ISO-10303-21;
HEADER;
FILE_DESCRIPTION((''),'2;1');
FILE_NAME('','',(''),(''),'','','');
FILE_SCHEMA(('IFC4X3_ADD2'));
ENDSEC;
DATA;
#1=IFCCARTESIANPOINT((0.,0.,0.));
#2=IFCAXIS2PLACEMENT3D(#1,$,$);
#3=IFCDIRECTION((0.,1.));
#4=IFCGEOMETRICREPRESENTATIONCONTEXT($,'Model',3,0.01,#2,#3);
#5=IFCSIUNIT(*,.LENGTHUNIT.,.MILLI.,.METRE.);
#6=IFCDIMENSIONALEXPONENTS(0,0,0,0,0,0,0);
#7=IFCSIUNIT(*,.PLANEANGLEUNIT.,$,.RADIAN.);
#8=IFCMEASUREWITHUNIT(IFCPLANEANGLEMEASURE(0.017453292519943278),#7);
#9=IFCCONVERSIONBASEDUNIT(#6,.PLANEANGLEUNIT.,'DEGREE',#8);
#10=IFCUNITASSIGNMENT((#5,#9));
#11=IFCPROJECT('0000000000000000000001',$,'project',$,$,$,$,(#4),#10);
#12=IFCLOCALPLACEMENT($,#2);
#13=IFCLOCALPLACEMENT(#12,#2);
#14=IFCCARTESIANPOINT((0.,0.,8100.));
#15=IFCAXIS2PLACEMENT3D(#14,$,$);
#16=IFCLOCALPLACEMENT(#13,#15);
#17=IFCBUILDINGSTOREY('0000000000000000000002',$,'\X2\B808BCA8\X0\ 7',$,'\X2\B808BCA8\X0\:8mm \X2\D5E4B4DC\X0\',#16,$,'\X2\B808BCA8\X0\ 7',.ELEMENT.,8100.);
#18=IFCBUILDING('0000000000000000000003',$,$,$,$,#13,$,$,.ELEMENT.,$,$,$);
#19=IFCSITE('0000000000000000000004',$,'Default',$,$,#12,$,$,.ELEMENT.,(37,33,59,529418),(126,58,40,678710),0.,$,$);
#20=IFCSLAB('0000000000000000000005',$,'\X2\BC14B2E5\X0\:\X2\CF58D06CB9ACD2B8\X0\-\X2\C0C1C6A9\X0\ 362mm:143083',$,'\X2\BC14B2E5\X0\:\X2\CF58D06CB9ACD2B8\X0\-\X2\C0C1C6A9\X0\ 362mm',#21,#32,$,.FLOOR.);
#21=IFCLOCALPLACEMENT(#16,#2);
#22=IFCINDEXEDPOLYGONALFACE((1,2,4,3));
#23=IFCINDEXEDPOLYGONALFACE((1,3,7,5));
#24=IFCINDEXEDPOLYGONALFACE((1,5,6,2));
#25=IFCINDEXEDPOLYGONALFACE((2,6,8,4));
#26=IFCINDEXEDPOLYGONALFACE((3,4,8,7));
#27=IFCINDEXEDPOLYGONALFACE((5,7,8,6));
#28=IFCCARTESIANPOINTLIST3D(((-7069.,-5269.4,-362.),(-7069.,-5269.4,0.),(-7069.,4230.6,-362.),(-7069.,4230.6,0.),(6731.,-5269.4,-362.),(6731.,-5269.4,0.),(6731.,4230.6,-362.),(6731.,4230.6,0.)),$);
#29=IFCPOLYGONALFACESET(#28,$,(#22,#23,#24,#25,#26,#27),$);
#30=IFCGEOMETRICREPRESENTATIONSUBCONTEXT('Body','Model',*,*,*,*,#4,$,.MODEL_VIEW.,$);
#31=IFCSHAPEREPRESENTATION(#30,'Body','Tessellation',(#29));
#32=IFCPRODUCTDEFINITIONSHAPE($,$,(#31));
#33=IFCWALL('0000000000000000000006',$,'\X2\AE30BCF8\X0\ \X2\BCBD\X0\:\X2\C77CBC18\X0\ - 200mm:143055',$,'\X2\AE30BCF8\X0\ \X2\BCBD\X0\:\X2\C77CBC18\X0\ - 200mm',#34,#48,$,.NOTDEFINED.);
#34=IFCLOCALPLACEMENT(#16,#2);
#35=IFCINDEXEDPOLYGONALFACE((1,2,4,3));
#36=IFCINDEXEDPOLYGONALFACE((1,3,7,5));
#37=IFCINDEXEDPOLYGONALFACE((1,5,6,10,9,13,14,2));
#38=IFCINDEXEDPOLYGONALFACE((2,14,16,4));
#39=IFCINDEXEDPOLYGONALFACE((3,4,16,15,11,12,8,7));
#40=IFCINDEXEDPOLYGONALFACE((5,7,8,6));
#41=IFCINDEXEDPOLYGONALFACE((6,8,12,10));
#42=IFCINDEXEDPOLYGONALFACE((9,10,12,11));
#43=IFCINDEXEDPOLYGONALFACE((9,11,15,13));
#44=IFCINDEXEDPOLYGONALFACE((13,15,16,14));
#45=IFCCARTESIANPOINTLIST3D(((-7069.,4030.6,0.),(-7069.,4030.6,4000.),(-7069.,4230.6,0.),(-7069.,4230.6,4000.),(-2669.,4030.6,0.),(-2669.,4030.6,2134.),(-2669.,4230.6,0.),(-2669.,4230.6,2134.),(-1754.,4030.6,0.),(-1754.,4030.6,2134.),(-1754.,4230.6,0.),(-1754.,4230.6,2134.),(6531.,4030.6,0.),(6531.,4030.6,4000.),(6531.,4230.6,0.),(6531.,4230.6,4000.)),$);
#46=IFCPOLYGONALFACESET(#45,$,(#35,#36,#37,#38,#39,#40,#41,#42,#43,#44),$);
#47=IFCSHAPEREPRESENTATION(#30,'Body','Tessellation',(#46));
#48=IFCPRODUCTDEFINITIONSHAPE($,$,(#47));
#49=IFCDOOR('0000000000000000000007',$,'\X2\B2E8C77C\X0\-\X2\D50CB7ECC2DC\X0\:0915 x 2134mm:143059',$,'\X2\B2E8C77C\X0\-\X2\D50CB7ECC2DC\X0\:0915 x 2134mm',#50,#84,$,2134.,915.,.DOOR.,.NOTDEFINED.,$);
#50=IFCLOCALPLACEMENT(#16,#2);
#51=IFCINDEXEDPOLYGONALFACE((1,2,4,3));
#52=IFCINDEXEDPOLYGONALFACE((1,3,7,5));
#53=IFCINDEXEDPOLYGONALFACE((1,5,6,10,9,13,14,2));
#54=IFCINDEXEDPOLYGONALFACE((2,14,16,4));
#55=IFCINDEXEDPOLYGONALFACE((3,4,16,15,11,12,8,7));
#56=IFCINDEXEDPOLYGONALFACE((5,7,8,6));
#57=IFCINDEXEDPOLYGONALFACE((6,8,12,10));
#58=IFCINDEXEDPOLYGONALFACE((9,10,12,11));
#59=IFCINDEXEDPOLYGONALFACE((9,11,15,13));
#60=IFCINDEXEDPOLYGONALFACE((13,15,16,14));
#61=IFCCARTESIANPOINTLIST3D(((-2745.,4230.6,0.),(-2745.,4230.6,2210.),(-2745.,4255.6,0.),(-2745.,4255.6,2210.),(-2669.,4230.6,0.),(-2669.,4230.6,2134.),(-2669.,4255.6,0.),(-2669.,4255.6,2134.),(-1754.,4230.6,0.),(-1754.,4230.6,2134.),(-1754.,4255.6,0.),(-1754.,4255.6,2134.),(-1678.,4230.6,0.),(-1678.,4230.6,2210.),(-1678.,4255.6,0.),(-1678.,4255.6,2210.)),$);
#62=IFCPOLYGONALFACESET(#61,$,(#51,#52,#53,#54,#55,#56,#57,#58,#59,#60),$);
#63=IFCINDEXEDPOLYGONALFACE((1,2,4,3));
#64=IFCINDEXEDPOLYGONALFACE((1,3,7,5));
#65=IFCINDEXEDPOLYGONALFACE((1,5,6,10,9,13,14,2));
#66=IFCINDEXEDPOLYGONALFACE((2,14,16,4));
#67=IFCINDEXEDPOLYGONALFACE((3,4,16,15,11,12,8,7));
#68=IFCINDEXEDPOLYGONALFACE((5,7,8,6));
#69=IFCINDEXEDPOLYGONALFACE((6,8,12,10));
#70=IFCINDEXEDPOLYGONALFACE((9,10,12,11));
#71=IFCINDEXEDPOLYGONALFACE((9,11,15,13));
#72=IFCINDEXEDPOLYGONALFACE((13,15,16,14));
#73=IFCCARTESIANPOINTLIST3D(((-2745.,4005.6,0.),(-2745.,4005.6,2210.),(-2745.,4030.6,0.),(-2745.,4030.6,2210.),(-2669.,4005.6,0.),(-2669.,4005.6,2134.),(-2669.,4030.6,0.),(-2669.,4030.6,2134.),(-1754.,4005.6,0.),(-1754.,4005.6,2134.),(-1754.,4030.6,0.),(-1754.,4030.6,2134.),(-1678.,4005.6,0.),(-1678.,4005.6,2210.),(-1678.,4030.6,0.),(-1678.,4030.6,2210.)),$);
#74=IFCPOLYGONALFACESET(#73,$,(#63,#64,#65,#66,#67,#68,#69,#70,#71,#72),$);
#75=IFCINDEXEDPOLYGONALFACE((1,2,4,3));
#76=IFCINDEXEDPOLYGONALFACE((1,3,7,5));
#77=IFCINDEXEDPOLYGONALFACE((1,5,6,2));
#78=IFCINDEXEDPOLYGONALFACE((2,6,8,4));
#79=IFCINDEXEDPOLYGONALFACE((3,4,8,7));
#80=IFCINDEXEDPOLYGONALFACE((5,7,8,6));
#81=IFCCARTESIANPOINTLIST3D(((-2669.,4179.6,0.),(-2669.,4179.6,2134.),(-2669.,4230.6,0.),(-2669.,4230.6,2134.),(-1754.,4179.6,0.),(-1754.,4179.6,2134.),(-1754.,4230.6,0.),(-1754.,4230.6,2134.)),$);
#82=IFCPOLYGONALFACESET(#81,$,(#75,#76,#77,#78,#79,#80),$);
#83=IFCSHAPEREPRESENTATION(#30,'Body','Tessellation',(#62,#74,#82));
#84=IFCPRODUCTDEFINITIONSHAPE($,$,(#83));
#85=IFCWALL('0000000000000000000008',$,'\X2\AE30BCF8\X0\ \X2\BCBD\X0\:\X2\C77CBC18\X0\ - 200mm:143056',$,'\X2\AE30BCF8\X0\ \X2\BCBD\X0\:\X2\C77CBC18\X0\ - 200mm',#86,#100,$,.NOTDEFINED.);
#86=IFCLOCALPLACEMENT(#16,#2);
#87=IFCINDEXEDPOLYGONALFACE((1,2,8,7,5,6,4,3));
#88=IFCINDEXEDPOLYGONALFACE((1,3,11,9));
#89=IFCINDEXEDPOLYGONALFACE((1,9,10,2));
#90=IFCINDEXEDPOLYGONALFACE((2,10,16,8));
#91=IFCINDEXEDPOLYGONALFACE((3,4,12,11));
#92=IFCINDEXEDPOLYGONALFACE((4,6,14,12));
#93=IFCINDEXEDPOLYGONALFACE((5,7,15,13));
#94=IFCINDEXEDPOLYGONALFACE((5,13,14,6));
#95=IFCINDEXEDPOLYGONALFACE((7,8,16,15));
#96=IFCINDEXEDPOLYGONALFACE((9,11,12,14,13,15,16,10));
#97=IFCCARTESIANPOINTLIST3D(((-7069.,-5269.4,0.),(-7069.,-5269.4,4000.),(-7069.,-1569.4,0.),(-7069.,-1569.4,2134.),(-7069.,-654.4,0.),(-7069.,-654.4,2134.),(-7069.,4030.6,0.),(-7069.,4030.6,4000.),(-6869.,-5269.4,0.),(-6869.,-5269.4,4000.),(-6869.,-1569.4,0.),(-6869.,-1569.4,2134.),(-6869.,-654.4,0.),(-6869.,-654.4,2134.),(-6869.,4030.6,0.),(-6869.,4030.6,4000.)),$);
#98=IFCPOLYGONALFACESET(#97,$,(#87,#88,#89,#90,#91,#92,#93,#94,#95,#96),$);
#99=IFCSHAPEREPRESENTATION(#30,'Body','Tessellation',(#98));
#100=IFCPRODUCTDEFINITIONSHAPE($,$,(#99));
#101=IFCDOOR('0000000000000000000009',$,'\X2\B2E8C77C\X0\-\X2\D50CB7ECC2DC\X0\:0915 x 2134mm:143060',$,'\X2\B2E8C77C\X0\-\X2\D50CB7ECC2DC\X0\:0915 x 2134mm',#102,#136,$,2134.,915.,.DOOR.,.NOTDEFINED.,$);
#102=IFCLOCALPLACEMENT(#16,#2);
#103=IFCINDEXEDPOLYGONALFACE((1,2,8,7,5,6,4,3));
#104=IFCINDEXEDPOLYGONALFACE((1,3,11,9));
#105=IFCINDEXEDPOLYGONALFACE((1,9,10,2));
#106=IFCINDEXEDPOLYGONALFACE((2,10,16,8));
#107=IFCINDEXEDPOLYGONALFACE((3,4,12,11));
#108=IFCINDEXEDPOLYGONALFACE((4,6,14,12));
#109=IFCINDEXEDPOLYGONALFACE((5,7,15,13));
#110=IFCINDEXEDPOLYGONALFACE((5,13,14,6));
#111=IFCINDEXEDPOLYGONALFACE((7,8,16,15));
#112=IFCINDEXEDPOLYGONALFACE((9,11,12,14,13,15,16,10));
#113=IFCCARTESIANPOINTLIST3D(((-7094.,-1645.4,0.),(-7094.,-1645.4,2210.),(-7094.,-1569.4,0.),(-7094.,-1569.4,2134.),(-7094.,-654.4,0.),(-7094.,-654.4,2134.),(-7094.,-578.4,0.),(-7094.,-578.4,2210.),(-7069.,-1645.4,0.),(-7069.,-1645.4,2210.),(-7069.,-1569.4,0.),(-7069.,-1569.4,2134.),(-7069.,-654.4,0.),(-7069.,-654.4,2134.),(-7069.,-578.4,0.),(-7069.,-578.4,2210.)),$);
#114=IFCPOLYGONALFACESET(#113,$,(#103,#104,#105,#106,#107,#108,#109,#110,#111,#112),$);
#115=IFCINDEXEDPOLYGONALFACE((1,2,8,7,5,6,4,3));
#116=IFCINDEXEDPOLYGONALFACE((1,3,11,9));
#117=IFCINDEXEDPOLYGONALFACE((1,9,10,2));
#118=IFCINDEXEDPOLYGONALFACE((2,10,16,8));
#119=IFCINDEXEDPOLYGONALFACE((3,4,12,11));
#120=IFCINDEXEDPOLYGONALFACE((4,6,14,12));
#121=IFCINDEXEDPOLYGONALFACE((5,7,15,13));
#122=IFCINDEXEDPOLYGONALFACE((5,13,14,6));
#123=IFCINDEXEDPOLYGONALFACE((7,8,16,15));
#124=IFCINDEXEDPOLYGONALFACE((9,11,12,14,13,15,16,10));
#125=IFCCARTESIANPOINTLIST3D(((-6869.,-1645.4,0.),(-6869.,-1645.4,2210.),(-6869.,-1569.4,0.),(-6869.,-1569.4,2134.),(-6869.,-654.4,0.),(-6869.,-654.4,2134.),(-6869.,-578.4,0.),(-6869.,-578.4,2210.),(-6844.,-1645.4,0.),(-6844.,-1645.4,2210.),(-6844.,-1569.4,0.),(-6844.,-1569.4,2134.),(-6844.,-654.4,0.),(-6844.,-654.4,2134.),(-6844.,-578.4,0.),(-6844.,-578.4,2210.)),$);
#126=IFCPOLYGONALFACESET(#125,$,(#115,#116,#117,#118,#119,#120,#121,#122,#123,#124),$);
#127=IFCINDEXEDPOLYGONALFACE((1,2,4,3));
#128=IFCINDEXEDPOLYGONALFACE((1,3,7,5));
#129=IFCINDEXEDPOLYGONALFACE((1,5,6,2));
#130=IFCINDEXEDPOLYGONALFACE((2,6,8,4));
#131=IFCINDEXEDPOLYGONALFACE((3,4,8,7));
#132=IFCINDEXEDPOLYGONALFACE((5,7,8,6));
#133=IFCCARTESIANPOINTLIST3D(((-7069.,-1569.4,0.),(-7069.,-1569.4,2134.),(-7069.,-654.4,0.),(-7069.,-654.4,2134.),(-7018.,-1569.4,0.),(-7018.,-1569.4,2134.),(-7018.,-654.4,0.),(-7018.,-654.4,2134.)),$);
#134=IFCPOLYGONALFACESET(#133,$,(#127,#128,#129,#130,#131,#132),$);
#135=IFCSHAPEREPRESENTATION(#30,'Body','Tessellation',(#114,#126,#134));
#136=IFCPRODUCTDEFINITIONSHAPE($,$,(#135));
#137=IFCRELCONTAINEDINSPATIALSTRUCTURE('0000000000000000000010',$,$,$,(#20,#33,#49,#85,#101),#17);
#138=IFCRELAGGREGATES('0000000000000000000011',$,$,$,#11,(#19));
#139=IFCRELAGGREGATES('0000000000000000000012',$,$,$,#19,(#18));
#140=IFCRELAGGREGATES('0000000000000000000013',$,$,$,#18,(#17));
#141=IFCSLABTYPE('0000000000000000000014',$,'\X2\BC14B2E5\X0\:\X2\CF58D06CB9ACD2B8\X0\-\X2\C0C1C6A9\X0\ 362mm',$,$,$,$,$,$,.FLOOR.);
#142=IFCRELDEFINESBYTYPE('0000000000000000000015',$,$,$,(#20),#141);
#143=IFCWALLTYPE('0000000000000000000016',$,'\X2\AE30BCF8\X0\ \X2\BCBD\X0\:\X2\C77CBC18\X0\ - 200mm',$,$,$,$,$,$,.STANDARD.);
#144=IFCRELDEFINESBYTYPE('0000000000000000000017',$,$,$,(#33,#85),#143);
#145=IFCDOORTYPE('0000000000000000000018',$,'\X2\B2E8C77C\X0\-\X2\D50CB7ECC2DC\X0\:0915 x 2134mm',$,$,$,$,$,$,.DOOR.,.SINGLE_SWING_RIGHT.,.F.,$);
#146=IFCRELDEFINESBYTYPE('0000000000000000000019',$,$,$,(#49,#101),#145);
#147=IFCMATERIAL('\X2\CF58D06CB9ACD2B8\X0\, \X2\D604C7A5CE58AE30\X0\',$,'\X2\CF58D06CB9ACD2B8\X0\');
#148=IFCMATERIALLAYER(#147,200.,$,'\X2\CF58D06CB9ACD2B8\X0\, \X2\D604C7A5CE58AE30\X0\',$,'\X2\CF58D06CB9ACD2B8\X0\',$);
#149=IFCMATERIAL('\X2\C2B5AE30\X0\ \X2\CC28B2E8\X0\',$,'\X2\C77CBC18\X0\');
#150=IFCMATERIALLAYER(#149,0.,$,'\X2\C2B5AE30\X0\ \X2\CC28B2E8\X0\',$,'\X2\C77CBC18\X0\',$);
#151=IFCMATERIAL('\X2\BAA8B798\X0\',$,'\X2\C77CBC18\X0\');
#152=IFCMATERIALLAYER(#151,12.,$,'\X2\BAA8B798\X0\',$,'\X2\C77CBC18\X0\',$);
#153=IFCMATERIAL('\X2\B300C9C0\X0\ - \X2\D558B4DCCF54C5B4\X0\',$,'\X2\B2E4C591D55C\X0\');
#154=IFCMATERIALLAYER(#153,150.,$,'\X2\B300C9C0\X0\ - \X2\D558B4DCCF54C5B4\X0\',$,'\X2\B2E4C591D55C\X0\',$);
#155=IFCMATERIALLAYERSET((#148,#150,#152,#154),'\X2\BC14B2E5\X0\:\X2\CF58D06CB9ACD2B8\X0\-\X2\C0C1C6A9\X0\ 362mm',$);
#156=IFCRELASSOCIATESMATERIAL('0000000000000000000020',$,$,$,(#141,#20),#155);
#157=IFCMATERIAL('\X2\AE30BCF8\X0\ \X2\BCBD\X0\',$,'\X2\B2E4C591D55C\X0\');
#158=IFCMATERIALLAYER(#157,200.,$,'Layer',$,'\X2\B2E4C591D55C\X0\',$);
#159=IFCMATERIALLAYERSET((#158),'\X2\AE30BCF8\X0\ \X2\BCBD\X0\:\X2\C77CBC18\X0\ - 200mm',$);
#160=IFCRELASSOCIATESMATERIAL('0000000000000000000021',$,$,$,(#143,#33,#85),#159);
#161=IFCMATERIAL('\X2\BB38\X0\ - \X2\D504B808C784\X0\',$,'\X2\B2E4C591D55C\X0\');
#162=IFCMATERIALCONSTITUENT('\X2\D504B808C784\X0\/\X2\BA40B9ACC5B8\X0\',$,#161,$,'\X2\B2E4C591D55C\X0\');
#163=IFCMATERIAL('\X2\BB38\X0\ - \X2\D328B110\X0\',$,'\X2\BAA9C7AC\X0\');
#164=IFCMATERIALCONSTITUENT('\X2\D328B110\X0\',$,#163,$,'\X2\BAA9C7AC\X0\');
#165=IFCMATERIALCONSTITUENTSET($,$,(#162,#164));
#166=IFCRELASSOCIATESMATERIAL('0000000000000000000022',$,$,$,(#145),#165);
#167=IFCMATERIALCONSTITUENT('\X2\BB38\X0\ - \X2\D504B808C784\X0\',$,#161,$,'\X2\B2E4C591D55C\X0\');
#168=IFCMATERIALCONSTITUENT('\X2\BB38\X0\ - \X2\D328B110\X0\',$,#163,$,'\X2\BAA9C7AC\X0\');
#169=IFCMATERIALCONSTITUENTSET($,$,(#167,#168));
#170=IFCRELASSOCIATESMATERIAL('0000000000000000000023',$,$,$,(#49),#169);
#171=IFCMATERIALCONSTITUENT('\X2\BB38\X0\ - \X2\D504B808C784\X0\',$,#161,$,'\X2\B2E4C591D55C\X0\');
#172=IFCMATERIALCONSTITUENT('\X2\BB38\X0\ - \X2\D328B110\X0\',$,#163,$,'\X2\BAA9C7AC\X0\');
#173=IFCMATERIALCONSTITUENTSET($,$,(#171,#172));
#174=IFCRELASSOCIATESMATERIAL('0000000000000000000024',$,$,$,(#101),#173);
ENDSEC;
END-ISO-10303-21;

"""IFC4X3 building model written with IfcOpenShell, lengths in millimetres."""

from ifc_helpers import new_model, entity, si_unit, converted_unit, direction, frame, frame_2d, origin, origin_2d_with_axis, place, context, subcontext, project, spatial, polyline, rectangle, outline, extrude, source, transform, mapped, material, layer, layer_set, layer_usage, constituent, constituent_set, type_object, type_shapes, element, fill, save


model = new_model("IFC4X3")

# Units and contexts
model_context = context("Model", 3, precision=0.01, world=origin(), true_north=direction((0.0, 1.0)))
body_context = subcontext(model_context, "Body", "Model", "MODEL_VIEW")
ifc_project = project(units=[si_unit("LENGTHUNIT", "METRE", prefix="MILLI"), converted_unit("PLANEANGLEUNIT", "DEGREE", entity("IfcPlaneAngleMeasure", 0.017453292519943278), si_unit("PLANEANGLEUNIT", "RADIAN"), dimensions=[0, 0, 0, 0, 0, 0, 0])], contexts=[model_context])

# Site, building, storey
site_placement = place(None, origin())
site = spatial("IfcSite", under=ifc_project, at=site_placement, Name="Default", CompositionType="ELEMENT", RefLatitude=(37, 33, 59, 529418), RefLongitude=(126, 58, 40, 678710), RefElevation=0.0)
building_placement = place(site_placement, origin())
building = spatial("IfcBuilding", under=site, at=building_placement, CompositionType="ELEMENT")
storey_placement = place(building_placement, frame((0.0, 0.0, 8100.0)))
storey = spatial("IfcBuildingStorey", under=building, at=storey_placement, Name="레벨 7", ObjectType="레벨:8mm 헤드", LongName="레벨 7", CompositionType="ELEMENT", Elevation=8100.0)

# Slab
ifc_material_1 = material(Name="콘크리트, 현장치기", Category="콘크리트")
ifc_layer_1 = layer(ifc_material_1, 200.0, Name="콘크리트, 현장치기", Category="콘크리트")
ifc_material_2 = material(Name="습기 차단", Category="일반")
ifc_layer_2 = layer(ifc_material_2, 0.0, Name="습기 차단", Category="일반")
ifc_material_3 = material(Name="모래", Category="일반")
ifc_layer_3 = layer(ifc_material_3, 12.0, Name="모래", Category="일반")
ifc_material_4 = material(Name="대지 - 하드코어", Category="다양한")
ifc_layer_4 = layer(ifc_material_4, 150.0, Name="대지 - 하드코어", Category="다양한")
ifc_layer_set_1 = layer_set([ifc_layer_1, ifc_layer_2, ifc_layer_3, ifc_layer_4], Name="바닥:콘크리트-상용 362mm")
ifc_layer_usage_1 = layer_usage(ifc_layer_set_1, "AXIS3", "POSITIVE", 0.0)
slab_type = type_object("IfcSlabType", Name="바닥:콘크리트-상용 362mm", PredefinedType="FLOOR", material=ifc_layer_set_1)
slab_placement = place(storey_placement, origin())
element("IfcSlab", 1, at=slab_placement, inside=storey, type_object=slab_type, material=ifc_layer_usage_1, Name="바닥:콘크리트-상용 362mm:143083", ObjectType="바닥:콘크리트-상용 362mm", PredefinedType="FLOOR", context=body_context, shape_type="SweptSolid", body=[
    extrude(rectangle(XDim=9500.0, YDim=13800.0, at=origin_2d_with_axis()), frame((-169.0, -519.4, 0.0), z_axis=(0.0, 0.0, -1.0), x_axis=(0.0, 1.0, 0.0)), (0.0, 0.0, 1.0), 362.0),
])

# Walls, openings, doors
ifc_material_5 = material(Name="기본 벽", Category="다양한")
ifc_layer_5 = layer(ifc_material_5, 200.0, Name="Layer", Category="다양한")
ifc_layer_set_2 = layer_set([ifc_layer_5], Name="기본 벽:일반 - 200mm")
wall_type = type_object("IfcWallType", Name="기본 벽:일반 - 200mm", PredefinedType="STANDARD", material=ifc_layer_set_2)
wall_1_placement = place(storey_placement, frame((-7069.0, 4130.6, 0.0)))
wall_1 = element("IfcWall", 2, at=wall_1_placement, inside=storey, type_object=wall_type, material=ifc_layer_set_2, Name="기본 벽:일반 - 200mm:143055", ObjectType="기본 벽:일반 - 200mm", PredefinedType="NOTDEFINED", context=body_context, shape_type="SweptSolid", body=[
    extrude(rectangle(XDim=13600.0, YDim=200.0, at=frame_2d((6800.0, 0.0), x_axis=(1.0, 0.0))), origin(), (0.0, 0.0, 1.0), 4000.0),
])
opening_1_placement = place(wall_1_placement, frame((4400.0, -100.0, 0.0)))
opening_1 = element("IfcOpeningElement", 3, at=opening_1_placement, cuts=wall_1, PredefinedType="OPENING", context=body_context, shape_type="SweptSolid", body=[
    extrude(rectangle(XDim=915.0, YDim=2134.0, at=frame_2d((1067.0, 457.5), x_axis=(0.0, 1.0))), frame((0.0, 0.0, 0.0), z_axis=(0.0, 1.0, 0.0), x_axis=(0.0, 0.0, 1.0)), (0.0, 0.0, 1.0), 200.0),
])
ifc_material_6 = material(Name="문 - 프레임", Category="다양한")
ifc_constituent_1 = constituent(ifc_material_6, Name="문 - 프레임", Category="다양한")
ifc_material_7 = material(Name="문 - 패널", Category="목재")
ifc_constituent_2 = constituent(ifc_material_7, Name="문 - 패널", Category="목재")
ifc_constituent_set_1 = constituent_set(constituents=[ifc_constituent_1, ifc_constituent_2])
ifc_constituent_3 = constituent(ifc_material_6, Name="프레임/멀리언", Category="다양한")
ifc_constituent_4 = constituent(ifc_material_7, Name="패널", Category="목재")
ifc_constituent_set_2 = constituent_set(constituents=[ifc_constituent_3, ifc_constituent_4])
door_type = type_object("IfcDoorType", Name="단일-플러시:0915 x 2134mm", OperationType="SINGLE_SWING_RIGHT", ParameterTakesPrecedence=False, PredefinedType="DOOR", material=ifc_constituent_set_2)
shared_shape_1 = source(origin(), body_context, "Body", "SweptSolid", [
    extrude(outline(polyline([(-533.5, -1124.0), (533.5, -1124.0), (533.5, 1086.0), (457.5, 1086.0), (457.5, -1048.0), (-457.5, -1048.0), (-457.5, 1086.0), (-533.5, 1086.0), (-533.5, -1124.0)])), frame((457.5, 200.0, 1086.0), z_axis=(0.0, 1.0, 0.0), x_axis=(1.0, 0.0, 0.0)), (0.0, 0.0, 1.0), 25.0),
    extrude(outline(polyline([(-1124.0, -533.5), (1086.0, -533.5), (1086.0, -457.5), (-1048.0, -457.5), (-1048.0, 457.5), (1086.0, 457.5), (1086.0, 533.5), (-1124.0, 533.5), (-1124.0, -533.5)])), frame((457.5, -25.0, 1086.0), z_axis=(0.0, 1.0, 0.0), x_axis=(0.0, 0.0, -1.0)), (0.0, 0.0, 1.0), 25.0),
    extrude(rectangle(XDim=51.0, YDim=915.0, at=frame_2d((0.0, 0.0), x_axis=(1.0, 0.0))), frame((457.5, 174.5, 0.0), z_axis=(0.0, 0.0, 1.0), x_axis=(0.0, 1.0, 0.0)), (0.0, 0.0, 1.0), 2134.0),
])
type_shapes(door_type, [shared_shape_1])
door_1_placement = place(opening_1_placement, origin())
door_1 = element("IfcDoor", 4, at=door_1_placement, inside=storey, type_object=door_type, material=ifc_constituent_set_1, Name="단일-플러시:0915 x 2134mm:143059", ObjectType="단일-플러시:0915 x 2134mm", OperationType="NOTDEFINED", OverallHeight=2134.0, OverallWidth=915.0, PredefinedType="DOOR", context=body_context, shape_type="MappedRepresentation", body=[
    mapped(shared_shape_1, transform((0.0, 0.0, 0.0), scale=1.0)),
])
fill(opening_1, door_1)
wall_2_placement = place(storey_placement, frame((-6969.0, -5269.4, 0.0), z_axis=(0.0, 0.0, 1.0), x_axis=(0.0, 1.0, 0.0)))
wall_2 = element("IfcWall", 5, at=wall_2_placement, inside=storey, type_object=wall_type, material=ifc_layer_set_2, Name="기본 벽:일반 - 200mm:143056", ObjectType="기본 벽:일반 - 200mm", PredefinedType="NOTDEFINED", context=body_context, shape_type="SweptSolid", body=[
    extrude(rectangle(XDim=9300.0, YDim=200.0, at=frame_2d((4650.0, 0.0), x_axis=(1.0, 0.0))), origin(), (0.0, 0.0, 1.0), 4000.0),
])
opening_2_placement = place(wall_2_placement, frame((3700.0, -100.0, 0.0)))
opening_2 = element("IfcOpeningElement", 6, at=opening_2_placement, cuts=wall_2, PredefinedType="OPENING", context=body_context, shape_type="SweptSolid", body=[
    extrude(rectangle(XDim=915.0, YDim=2134.0, at=frame_2d((1067.0, 457.5), x_axis=(0.0, 1.0))), frame((0.0, 0.0, 0.0), z_axis=(0.0, 1.0, 0.0), x_axis=(0.0, 0.0, 1.0)), (0.0, 0.0, 1.0), 200.0),
])
ifc_constituent_5 = constituent(ifc_material_6, Name="문 - 프레임", Category="다양한")
ifc_constituent_6 = constituent(ifc_material_7, Name="문 - 패널", Category="목재")
ifc_constituent_set_3 = constituent_set(constituents=[ifc_constituent_5, ifc_constituent_6])
door_2_placement = place(opening_2_placement, origin())
door_2 = element("IfcDoor", 7, at=door_2_placement, inside=storey, type_object=door_type, material=ifc_constituent_set_3, Name="단일-플러시:0915 x 2134mm:143060", ObjectType="단일-플러시:0915 x 2134mm", OperationType="NOTDEFINED", OverallHeight=2134.0, OverallWidth=915.0, PredefinedType="DOOR", context=body_context, shape_type="MappedRepresentation", body=[
    mapped(shared_shape_1, transform((0.0, 0.0, 0.0), scale=1.0)),
])
fill(opening_2, door_2)

save(model, "model.ifc")
